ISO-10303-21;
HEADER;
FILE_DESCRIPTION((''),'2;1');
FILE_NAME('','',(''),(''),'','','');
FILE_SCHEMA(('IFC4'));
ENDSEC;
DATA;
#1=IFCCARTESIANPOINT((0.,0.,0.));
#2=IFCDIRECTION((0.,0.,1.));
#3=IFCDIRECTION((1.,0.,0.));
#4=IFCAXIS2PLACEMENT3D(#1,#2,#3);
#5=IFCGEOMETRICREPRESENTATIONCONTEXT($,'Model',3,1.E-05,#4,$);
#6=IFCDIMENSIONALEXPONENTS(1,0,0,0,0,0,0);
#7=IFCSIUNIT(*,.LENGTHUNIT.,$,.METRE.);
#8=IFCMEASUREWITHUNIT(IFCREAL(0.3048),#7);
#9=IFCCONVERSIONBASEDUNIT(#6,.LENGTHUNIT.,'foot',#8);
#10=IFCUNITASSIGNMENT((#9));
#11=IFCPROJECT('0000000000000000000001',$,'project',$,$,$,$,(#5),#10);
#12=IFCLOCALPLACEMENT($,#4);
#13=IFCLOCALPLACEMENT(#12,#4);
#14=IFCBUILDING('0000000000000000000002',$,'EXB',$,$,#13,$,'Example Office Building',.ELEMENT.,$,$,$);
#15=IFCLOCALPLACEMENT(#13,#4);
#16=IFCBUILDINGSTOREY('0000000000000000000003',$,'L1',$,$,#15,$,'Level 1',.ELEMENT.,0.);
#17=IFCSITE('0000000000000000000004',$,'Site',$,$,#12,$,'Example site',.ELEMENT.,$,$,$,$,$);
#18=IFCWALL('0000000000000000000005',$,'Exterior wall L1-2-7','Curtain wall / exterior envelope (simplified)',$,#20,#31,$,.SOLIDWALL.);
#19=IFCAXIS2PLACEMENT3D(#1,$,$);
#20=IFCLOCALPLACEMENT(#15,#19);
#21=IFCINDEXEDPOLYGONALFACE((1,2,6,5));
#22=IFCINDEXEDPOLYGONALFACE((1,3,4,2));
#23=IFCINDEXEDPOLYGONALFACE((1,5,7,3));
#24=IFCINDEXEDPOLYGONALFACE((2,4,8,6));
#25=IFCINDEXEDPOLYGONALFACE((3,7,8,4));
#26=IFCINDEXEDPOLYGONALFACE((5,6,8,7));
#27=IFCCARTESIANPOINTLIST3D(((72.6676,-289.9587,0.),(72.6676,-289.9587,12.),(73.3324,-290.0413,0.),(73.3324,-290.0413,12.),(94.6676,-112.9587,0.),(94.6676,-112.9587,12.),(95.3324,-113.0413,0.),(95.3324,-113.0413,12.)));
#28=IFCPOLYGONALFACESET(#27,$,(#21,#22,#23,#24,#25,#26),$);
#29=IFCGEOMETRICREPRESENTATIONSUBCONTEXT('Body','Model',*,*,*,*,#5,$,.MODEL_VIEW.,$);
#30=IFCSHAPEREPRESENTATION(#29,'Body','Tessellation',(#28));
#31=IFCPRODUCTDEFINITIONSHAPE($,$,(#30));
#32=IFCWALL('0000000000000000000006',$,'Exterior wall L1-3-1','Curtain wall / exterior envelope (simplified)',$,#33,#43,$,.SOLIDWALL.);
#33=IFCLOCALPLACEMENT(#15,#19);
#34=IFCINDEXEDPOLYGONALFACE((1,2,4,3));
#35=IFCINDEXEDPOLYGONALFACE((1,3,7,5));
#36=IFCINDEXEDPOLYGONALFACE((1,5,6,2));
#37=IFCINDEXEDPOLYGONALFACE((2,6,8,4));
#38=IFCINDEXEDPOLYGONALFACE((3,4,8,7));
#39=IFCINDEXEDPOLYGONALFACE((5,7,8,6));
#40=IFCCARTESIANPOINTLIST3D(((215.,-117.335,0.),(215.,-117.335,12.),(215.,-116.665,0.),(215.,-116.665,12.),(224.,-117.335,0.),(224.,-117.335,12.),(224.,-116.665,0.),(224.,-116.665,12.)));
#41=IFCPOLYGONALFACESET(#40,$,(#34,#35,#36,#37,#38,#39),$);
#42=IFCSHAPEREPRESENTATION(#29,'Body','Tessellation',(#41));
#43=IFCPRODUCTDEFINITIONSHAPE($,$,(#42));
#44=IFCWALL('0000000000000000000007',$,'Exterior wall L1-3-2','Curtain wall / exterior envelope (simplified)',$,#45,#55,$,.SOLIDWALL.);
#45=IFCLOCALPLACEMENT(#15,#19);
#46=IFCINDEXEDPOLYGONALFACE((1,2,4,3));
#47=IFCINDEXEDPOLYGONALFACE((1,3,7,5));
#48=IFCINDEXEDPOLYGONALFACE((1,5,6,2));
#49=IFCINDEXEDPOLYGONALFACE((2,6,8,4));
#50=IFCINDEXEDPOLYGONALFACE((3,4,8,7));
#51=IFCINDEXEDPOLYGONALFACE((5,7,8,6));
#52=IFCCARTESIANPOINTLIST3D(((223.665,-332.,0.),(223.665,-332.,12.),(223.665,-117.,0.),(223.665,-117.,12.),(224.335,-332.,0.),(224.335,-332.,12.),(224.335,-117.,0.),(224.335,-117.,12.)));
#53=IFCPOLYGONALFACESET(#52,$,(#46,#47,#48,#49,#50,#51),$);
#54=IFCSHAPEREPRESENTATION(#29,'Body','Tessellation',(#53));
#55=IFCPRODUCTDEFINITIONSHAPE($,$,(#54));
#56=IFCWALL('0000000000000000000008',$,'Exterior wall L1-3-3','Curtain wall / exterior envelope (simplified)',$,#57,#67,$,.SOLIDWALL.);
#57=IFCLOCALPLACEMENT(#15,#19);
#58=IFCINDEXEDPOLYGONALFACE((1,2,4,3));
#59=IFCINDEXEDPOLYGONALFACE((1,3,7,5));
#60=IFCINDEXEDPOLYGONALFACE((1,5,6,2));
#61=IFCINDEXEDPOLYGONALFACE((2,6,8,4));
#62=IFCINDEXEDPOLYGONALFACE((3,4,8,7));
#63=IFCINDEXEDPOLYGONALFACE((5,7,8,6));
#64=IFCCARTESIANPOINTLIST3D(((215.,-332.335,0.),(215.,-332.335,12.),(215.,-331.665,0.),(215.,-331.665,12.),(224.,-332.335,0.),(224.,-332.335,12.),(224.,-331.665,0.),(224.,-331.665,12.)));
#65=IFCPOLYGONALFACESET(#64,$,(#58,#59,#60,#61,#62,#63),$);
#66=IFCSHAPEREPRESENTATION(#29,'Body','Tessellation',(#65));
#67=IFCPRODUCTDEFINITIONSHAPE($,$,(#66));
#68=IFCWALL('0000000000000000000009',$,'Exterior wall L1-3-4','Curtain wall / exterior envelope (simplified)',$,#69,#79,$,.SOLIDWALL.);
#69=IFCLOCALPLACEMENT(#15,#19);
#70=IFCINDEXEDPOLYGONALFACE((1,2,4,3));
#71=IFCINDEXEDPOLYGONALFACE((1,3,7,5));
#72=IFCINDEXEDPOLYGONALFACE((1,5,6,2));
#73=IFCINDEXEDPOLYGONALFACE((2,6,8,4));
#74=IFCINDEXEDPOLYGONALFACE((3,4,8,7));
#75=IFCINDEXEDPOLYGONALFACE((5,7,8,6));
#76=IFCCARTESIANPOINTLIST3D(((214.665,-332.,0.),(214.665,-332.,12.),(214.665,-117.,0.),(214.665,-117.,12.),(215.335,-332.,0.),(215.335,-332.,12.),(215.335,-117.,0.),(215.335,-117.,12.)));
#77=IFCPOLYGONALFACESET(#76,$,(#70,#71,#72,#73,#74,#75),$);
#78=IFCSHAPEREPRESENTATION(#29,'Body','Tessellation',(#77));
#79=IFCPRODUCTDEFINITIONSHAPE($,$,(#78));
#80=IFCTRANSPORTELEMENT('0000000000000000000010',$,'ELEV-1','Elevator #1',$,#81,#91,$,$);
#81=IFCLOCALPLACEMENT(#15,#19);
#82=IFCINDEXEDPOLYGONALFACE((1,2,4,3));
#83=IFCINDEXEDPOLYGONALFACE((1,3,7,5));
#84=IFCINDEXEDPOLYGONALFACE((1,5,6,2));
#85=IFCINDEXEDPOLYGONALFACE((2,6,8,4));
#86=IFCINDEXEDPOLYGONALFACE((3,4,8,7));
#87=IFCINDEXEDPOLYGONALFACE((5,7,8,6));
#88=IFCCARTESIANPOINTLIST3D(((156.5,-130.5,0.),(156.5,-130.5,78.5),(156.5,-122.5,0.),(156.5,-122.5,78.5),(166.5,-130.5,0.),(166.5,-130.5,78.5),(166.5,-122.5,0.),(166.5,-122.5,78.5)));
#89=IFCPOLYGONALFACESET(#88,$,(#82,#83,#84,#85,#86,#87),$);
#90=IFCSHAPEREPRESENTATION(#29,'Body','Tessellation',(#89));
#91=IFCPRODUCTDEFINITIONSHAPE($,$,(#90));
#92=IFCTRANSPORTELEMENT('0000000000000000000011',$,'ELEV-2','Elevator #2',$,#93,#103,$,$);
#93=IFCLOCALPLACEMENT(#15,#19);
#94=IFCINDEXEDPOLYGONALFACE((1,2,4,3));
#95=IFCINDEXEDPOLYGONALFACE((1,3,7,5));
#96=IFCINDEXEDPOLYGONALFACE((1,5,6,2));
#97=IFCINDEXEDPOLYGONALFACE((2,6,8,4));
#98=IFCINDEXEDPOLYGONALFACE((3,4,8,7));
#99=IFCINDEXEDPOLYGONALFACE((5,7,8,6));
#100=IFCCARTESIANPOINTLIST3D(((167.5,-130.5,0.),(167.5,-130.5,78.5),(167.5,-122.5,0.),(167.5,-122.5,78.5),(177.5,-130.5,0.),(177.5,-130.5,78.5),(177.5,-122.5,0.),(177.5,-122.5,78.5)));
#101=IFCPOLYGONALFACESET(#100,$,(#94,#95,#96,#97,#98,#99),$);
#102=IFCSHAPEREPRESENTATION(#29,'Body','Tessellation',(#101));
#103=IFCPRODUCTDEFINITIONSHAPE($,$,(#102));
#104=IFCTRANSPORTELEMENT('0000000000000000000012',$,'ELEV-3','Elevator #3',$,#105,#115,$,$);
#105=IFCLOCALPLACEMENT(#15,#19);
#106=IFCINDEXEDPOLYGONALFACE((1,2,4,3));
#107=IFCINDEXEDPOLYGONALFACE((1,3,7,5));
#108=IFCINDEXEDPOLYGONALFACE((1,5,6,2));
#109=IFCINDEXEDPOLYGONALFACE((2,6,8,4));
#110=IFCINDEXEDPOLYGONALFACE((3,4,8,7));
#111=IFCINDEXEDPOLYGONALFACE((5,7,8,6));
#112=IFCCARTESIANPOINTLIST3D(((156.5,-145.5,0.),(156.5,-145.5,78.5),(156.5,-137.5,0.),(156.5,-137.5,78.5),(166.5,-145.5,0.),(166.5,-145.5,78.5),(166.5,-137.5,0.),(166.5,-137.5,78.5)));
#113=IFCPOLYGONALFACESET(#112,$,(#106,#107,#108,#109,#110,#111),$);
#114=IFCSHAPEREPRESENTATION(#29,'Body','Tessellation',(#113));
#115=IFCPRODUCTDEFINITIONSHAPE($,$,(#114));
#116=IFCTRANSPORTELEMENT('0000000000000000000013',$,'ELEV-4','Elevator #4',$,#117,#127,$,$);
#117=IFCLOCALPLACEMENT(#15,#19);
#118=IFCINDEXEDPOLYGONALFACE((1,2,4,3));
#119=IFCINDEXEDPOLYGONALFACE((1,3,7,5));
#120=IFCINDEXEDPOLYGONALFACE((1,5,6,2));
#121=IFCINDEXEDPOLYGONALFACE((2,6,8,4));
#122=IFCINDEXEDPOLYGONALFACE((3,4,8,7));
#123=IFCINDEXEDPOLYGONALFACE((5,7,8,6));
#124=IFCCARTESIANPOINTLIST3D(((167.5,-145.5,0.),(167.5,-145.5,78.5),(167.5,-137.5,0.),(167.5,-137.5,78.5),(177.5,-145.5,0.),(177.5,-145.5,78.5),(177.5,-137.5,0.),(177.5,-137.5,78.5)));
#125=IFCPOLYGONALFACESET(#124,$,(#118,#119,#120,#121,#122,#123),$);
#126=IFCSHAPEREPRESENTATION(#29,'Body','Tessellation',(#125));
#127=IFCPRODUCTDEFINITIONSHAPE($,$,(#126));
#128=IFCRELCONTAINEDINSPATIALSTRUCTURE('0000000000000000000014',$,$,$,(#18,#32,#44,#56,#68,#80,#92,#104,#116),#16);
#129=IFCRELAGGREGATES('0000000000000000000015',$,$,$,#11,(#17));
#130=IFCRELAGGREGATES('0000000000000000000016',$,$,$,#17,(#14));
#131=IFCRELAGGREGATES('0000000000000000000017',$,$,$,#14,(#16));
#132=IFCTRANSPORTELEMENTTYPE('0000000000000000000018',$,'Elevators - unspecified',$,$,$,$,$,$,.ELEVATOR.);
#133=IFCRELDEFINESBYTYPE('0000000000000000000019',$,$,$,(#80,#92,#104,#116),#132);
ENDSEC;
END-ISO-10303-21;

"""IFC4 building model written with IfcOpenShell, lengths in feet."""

from ifc_helpers import new_model, entity, si_unit, converted_unit, frame, frame_2d, origin, origin_with_axes, origin_2d, place, context, subcontext, project, spatial, rectangle, extrude, type_object, element, save


model = new_model("IFC4")

# Units and contexts
model_context = context("Model", 3, precision=1e-05, world=origin_with_axes())
body_context = subcontext(model_context, "Body", "Model", "MODEL_VIEW")
ifc_project = project(units=[converted_unit("LENGTHUNIT", "foot", entity("IfcReal", 0.3048), si_unit("LENGTHUNIT", "METRE"), dimensions=[1, 0, 0, 0, 0, 0, 0])], contexts=[model_context])

# Site, building, storey
site_placement = place(None, origin_with_axes())
site = spatial("IfcSite", under=ifc_project, at=site_placement, Name="Site", LongName="Example site", CompositionType="ELEMENT")
building_placement = place(site_placement, origin_with_axes())
building = spatial("IfcBuilding", under=site, at=building_placement, Name="EXB", LongName="Example Office Building", CompositionType="ELEMENT")
storey_placement = place(building_placement, origin_with_axes())
storey = spatial("IfcBuildingStorey", under=building, at=storey_placement, Name="L1", LongName="Level 1", CompositionType="ELEMENT", Elevation=0.0)

# Walls
wall_1_placement = place(storey_placement, frame((73.0, -290.0, 0.0), z_axis=(0.0, 0.0, 1.0), x_axis=(0.123345, 0.992364, 0.0)))
element("IfcWall", 1, at=wall_1_placement, inside=storey, Name="Exterior wall L1-2-7", Description="Curtain wall / exterior envelope (simplified)", PredefinedType="SOLIDWALL", context=body_context, shape_type="SweptSolid", body=[
    extrude(rectangle(XDim=178.362, YDim=0.67, at=frame_2d((89.181, 0.0))), origin(), (0.0, 0.0, 1.0), 12.0),
])
wall_2_placement = place(storey_placement, frame((215.0, -117.0, 0.0), z_axis=(0.0, 0.0, 1.0), x_axis=(1.0, 0.0, 0.0)))
element("IfcWall", 2, at=wall_2_placement, inside=storey, Name="Exterior wall L1-3-1", Description="Curtain wall / exterior envelope (simplified)", PredefinedType="SOLIDWALL", context=body_context, shape_type="SweptSolid", body=[
    extrude(rectangle(XDim=9.0, YDim=0.67, at=frame_2d((4.5, 0.0))), origin(), (0.0, 0.0, 1.0), 12.0),
])
wall_3_placement = place(storey_placement, frame((224.0, -117.0, 0.0), z_axis=(0.0, 0.0, 1.0), x_axis=(0.0, -1.0, 0.0)))
element("IfcWall", 3, at=wall_3_placement, inside=storey, Name="Exterior wall L1-3-2", Description="Curtain wall / exterior envelope (simplified)", PredefinedType="SOLIDWALL", context=body_context, shape_type="SweptSolid", body=[
    extrude(rectangle(XDim=215.0, YDim=0.67, at=frame_2d((107.5, 0.0))), origin(), (0.0, 0.0, 1.0), 12.0),
])
wall_4_placement = place(storey_placement, frame((224.0, -332.0, 0.0), z_axis=(0.0, 0.0, 1.0), x_axis=(-1.0, 0.0, 0.0)))
element("IfcWall", 4, at=wall_4_placement, inside=storey, Name="Exterior wall L1-3-3", Description="Curtain wall / exterior envelope (simplified)", PredefinedType="SOLIDWALL", context=body_context, shape_type="SweptSolid", body=[
    extrude(rectangle(XDim=9.0, YDim=0.67, at=frame_2d((4.5, 0.0))), origin(), (0.0, 0.0, 1.0), 12.0),
])
wall_5_placement = place(storey_placement, frame((215.0, -332.0, 0.0), z_axis=(0.0, 0.0, 1.0), x_axis=(0.0, 1.0, 0.0)))
element("IfcWall", 5, at=wall_5_placement, inside=storey, Name="Exterior wall L1-3-4", Description="Curtain wall / exterior envelope (simplified)", PredefinedType="SOLIDWALL", context=body_context, shape_type="SweptSolid", body=[
    extrude(rectangle(XDim=215.0, YDim=0.67, at=frame_2d((107.5, 0.0))), origin(), (0.0, 0.0, 1.0), 12.0),
])

# Transport elements
transport_element_type = type_object("IfcTransportElementType", Name="Elevators - unspecified", PredefinedType="ELEVATOR")
for number, where, z_axis, x_axis, name, description in (
    (6, (161.5, -126.5, 0.0), (0.0, 0.0, 1.0), (1.0, 0.0, 0.0), "ELEV-1", "Elevator #1"),
    (7, (172.5, -126.5, 0.0), (0.0, 0.0, 1.0), (1.0, 0.0, 0.0), "ELEV-2", "Elevator #2"),
    (8, (161.5, -141.5, 0.0), (0.0, 0.0, 1.0), (1.0, 0.0, 0.0), "ELEV-3", "Elevator #3"),
    (9, (172.5, -141.5, 0.0), (0.0, 0.0, 1.0), (1.0, 0.0, 0.0), "ELEV-4", "Elevator #4"),
):
    element("IfcTransportElement", number, at=place(storey_placement, frame(where, z_axis=z_axis, x_axis=x_axis)), inside=storey, type_object=transport_element_type, Name=name, Description=description, context=body_context, shape_type="SweptSolid", body=[
        extrude(rectangle(XDim=10.0, YDim=8.0, at=origin_2d()), origin(), (0.0, 0.0, 1.0), 78.5),
    ])

save(model, "model.ifc")
